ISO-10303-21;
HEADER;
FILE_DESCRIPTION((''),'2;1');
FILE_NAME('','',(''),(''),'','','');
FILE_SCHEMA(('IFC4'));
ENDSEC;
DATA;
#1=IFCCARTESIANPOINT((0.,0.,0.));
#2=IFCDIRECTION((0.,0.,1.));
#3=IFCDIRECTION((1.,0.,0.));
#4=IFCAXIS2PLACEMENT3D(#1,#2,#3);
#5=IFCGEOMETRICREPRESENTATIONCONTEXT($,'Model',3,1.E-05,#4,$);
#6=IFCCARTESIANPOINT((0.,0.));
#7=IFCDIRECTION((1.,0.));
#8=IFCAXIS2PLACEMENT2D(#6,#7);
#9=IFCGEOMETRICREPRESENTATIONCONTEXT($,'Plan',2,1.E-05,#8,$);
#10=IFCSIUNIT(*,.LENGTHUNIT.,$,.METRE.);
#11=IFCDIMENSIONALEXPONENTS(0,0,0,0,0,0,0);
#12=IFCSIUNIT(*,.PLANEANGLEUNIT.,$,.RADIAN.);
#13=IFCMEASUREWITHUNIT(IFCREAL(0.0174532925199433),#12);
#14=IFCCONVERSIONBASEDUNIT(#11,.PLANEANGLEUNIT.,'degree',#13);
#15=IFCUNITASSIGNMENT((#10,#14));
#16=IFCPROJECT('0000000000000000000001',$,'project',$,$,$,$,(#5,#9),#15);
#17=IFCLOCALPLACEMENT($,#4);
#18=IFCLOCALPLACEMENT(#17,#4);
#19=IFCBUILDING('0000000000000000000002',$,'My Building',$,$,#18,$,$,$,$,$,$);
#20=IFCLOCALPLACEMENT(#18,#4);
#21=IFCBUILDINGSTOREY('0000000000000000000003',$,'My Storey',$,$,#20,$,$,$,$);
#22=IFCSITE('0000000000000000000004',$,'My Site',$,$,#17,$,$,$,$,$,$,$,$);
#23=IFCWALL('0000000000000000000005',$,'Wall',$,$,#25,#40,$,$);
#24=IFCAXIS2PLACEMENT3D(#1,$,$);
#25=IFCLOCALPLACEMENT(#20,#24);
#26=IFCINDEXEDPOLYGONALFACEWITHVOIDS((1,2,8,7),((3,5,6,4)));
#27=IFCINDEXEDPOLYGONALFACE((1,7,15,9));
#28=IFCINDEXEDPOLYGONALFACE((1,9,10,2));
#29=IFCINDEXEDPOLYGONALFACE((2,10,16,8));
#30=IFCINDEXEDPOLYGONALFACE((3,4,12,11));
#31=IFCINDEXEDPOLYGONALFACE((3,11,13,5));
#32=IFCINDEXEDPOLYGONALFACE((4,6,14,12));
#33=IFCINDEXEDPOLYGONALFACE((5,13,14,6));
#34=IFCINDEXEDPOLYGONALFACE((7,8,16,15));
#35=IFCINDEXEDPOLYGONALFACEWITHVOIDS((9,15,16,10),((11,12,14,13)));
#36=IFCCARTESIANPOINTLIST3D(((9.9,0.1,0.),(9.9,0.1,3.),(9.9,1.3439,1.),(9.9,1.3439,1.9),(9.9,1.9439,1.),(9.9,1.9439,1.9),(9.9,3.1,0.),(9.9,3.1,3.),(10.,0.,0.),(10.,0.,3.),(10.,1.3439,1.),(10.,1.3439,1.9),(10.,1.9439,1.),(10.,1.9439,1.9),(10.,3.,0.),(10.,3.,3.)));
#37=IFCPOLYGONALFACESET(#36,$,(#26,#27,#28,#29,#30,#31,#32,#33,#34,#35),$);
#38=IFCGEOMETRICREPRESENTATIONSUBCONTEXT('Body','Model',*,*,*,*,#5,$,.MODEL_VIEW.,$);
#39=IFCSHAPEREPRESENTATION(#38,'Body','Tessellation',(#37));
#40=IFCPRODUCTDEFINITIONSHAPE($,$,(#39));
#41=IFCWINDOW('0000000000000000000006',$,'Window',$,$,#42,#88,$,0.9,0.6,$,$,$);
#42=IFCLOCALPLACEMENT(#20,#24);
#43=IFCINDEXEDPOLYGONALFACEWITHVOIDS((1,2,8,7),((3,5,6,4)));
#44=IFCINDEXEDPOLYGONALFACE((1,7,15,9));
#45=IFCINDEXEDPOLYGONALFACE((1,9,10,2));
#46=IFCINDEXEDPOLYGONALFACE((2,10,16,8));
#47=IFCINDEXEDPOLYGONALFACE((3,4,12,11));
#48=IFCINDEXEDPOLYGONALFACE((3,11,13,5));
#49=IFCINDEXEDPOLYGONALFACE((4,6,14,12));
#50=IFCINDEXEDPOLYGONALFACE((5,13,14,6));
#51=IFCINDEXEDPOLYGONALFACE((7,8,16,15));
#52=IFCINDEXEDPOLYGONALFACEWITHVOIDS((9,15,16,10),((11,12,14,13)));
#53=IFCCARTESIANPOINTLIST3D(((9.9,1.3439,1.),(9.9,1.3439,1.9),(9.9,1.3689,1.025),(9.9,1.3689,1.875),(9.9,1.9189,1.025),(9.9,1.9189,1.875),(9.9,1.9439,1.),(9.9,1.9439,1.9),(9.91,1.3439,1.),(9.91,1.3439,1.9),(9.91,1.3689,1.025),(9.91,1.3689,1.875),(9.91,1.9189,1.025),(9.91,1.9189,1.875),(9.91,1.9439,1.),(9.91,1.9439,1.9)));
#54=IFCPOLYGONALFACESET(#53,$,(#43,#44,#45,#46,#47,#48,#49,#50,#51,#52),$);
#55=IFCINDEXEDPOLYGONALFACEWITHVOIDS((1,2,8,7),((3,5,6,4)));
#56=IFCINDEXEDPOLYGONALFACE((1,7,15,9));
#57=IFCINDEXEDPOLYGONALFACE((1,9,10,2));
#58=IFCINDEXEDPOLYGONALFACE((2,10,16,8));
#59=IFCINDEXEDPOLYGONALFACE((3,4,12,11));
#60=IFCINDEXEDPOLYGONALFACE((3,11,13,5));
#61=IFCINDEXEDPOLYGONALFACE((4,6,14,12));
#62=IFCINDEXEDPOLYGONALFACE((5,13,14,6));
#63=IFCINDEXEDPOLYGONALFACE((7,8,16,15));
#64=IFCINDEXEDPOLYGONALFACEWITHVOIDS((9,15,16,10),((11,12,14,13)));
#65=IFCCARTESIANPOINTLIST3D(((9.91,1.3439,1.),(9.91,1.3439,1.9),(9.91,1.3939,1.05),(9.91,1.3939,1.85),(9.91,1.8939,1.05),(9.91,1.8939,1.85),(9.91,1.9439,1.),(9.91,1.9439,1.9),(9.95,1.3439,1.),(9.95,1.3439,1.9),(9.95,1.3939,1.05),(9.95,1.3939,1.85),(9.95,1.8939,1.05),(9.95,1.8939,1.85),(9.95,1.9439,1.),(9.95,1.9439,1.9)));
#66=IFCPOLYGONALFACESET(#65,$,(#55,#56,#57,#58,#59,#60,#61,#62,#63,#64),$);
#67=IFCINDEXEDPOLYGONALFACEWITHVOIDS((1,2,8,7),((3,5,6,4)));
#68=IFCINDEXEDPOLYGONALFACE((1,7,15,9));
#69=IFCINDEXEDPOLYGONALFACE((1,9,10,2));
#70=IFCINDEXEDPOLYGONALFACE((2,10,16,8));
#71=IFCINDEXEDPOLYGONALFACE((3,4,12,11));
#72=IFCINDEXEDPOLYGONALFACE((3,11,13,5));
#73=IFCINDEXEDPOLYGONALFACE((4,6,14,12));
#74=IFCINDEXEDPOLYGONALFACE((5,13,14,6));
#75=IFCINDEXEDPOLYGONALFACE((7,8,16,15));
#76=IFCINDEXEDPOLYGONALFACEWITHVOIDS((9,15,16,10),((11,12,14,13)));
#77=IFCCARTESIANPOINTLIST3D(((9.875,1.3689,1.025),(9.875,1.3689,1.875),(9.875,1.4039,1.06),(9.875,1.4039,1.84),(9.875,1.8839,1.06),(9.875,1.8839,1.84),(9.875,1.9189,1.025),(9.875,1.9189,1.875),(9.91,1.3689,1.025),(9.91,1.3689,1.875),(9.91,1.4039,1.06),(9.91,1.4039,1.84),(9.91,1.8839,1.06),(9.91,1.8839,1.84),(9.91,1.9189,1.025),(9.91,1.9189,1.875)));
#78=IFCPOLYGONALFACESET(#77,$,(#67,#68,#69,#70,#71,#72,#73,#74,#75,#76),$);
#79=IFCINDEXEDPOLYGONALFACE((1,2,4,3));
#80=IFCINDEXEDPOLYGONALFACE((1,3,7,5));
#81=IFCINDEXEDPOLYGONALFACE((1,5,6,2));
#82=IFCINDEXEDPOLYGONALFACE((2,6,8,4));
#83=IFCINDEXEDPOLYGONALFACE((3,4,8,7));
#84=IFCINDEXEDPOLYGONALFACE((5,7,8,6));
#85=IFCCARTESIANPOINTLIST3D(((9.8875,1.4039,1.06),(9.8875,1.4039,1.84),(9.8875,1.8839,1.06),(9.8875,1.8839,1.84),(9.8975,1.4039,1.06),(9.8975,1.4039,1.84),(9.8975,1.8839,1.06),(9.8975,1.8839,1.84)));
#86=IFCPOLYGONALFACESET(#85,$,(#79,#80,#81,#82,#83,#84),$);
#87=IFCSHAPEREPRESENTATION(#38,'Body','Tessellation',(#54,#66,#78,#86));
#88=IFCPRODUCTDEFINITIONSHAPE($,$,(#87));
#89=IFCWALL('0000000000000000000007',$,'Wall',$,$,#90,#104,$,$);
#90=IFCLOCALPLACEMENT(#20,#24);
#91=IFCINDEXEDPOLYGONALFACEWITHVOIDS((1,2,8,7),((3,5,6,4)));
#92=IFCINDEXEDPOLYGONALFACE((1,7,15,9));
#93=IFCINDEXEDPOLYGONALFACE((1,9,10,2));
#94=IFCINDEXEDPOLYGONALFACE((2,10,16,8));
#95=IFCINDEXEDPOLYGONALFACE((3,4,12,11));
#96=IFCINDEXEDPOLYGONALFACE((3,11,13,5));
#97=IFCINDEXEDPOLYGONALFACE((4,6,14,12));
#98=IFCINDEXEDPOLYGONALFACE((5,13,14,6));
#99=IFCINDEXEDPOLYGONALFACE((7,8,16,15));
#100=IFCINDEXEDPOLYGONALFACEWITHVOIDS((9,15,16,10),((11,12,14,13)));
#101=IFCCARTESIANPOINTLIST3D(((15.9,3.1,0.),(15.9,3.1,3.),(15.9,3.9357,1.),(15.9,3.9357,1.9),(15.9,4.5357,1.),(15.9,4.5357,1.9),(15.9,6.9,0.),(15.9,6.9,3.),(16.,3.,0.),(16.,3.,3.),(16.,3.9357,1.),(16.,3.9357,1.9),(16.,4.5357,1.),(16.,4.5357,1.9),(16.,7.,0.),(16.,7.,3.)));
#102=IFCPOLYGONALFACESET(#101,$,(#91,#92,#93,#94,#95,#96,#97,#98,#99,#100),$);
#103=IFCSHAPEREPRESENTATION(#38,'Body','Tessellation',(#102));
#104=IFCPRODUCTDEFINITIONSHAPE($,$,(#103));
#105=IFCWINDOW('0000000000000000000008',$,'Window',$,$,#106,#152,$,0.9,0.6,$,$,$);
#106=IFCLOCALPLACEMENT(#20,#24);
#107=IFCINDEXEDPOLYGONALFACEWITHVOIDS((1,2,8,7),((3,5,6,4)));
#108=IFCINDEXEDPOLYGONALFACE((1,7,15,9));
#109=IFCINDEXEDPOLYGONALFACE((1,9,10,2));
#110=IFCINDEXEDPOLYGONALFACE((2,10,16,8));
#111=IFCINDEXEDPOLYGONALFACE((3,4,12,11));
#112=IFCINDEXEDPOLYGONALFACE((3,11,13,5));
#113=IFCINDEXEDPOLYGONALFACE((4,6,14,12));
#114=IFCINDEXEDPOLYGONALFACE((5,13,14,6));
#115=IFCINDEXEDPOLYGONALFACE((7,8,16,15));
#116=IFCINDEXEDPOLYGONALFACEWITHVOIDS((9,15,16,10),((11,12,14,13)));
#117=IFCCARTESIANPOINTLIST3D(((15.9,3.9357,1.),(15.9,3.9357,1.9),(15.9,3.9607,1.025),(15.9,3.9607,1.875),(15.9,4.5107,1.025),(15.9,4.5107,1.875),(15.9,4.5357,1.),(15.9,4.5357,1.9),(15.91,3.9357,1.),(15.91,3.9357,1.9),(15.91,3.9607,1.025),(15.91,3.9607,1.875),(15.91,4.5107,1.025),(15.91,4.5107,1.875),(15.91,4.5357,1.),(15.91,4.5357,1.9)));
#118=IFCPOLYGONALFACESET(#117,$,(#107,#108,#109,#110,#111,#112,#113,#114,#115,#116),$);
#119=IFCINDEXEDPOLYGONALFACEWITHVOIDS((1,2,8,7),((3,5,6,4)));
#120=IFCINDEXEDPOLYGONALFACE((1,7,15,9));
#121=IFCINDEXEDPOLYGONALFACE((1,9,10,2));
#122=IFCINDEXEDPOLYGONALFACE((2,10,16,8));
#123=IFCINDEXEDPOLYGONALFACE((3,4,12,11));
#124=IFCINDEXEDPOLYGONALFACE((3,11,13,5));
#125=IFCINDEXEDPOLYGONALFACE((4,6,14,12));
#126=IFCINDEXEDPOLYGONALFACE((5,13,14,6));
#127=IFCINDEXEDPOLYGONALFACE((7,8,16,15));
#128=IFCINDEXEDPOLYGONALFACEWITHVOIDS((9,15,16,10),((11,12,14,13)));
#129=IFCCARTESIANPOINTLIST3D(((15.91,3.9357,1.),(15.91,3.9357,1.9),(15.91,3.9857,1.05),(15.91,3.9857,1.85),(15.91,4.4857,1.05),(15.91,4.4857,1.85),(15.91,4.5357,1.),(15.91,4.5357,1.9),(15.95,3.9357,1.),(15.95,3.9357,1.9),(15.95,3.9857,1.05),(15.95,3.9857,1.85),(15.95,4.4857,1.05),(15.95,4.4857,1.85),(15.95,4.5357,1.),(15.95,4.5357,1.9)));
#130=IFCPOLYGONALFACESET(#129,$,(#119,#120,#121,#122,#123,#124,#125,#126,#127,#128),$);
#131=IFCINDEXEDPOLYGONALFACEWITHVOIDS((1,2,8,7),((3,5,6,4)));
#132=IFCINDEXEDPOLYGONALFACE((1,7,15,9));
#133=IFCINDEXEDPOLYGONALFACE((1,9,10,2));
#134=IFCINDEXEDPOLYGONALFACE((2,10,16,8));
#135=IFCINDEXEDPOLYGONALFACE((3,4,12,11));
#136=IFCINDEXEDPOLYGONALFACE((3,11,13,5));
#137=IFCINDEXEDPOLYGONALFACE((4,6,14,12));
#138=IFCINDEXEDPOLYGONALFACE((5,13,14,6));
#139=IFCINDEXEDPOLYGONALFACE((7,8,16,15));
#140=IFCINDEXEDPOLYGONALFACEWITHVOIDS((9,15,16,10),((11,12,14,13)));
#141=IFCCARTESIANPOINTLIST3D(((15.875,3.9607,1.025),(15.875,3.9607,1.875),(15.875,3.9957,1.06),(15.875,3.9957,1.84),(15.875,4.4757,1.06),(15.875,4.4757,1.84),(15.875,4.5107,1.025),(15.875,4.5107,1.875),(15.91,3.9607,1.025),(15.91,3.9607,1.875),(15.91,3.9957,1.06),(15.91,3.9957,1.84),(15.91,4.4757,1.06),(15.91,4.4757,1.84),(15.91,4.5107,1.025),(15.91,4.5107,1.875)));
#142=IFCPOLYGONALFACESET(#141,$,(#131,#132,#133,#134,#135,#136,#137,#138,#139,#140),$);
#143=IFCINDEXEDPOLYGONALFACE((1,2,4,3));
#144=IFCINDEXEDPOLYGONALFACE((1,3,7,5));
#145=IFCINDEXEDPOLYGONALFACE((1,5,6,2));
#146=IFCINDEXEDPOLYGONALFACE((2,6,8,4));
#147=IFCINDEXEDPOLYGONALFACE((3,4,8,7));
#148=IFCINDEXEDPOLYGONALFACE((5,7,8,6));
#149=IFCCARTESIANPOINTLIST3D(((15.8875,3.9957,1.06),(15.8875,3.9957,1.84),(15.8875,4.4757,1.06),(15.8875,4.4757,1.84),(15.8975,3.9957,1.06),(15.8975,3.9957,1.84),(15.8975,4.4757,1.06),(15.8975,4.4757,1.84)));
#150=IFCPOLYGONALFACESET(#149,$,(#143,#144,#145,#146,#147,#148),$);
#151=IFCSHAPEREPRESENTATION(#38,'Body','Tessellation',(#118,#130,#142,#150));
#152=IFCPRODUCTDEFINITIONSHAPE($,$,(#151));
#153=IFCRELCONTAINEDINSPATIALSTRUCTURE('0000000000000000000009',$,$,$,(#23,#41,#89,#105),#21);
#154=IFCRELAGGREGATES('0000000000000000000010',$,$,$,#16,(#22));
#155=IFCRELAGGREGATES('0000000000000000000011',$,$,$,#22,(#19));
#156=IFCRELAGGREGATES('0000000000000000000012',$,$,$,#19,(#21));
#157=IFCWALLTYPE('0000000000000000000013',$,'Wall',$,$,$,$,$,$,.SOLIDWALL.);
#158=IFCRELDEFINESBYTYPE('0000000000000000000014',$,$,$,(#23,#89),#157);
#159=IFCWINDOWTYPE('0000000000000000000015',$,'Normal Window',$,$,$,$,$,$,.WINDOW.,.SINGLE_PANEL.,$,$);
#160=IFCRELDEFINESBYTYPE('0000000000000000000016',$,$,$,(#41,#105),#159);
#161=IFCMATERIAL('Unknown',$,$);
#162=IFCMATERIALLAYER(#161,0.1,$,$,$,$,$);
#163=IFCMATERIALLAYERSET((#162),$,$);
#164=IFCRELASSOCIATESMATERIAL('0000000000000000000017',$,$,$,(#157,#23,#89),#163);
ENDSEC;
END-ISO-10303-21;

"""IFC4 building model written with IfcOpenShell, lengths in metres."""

from ifc_helpers import new_model, entity, si_unit, converted_unit, frame, origin_with_axes, origin_2d_with_axis, place, context, subcontext, project, spatial, line, indexed_curve, outline, extrude, shape, source, transform, mapped, material, layer, layer_set, layer_usage, type_object, type_shapes, element, fill, save


model = new_model("IFC4")

# Units and contexts
model_context = context("Model", 3, precision=1e-05, world=origin_with_axes())
plan_context = context("Plan", 2, precision=1e-05, world=origin_2d_with_axis())
body_context_1 = subcontext(model_context, "Body", "Model", "MODEL_VIEW")
body_context_2 = subcontext(plan_context, "Body", "Plan", "PLAN_VIEW")
ifc_project = project(units=[si_unit("LENGTHUNIT", "METRE"), converted_unit("PLANEANGLEUNIT", "degree", entity("IfcReal", 0.0174532925199433), si_unit("PLANEANGLEUNIT", "RADIAN"), dimensions=[0, 0, 0, 0, 0, 0, 0])], contexts=[model_context, plan_context])

# Site, building, storey
site_placement = place(None, origin_with_axes())
site = spatial("IfcSite", under=ifc_project, at=site_placement, Name="My Site")
building_placement = place(site_placement, origin_with_axes())
building = spatial("IfcBuilding", under=site, at=building_placement, Name="My Building")
storey_placement = place(building_placement, origin_with_axes())
storey = spatial("IfcBuildingStorey", under=building, at=storey_placement, Name="My Storey")

# Shared definitions
ifc_material = material(Name="Unknown")

# Walls, openings, windows
ifc_layer = layer(ifc_material, 0.1)
ifc_layer_set = layer_set([ifc_layer])
ifc_layer_usage_1 = layer_usage(ifc_layer_set, "AXIS2", "POSITIVE", 0.0)
wall_type = type_object("IfcWallType", Name="Wall", PredefinedType="SOLIDWALL", material=ifc_layer_set)
wall_1_placement = place(storey_placement, frame((10.0, 0.0, 0.0), z_axis=(0.0, 0.0, 1.0), x_axis=(0.0, 1.0, 0.0)))
wall_1 = element("IfcWall", 1, at=wall_1_placement, inside=storey, type_object=wall_type, material=ifc_layer_usage_1, Name="Wall", context=body_context_1, shape_type="SweptSolid", body=[
    extrude(outline(indexed_curve([(0.0, 0.0), (0.1, 0.1), (3.1, 0.1), (3.0, 0.0)], segments=[line(1, 2, 3, 4, 1)])), origin_with_axes(), (0.0, 0.0, 1.0), 3.0),
])
shared_shape_1 = source(origin_with_axes(), body_context_1, "Body", "SweptSolid", [
    extrude(outline(indexed_curve([(0.0, 0.0), (0.6, 0.0), (0.6, 0.9), (0.0, 0.9)], segments=[line(1, 2, 3, 4, 1)])), frame((0.0, -0.6, 0.0), z_axis=(0.0, -1.0, 0.0), x_axis=(1.0, 0.0, 0.0)), (0.0, 0.0, -1.0), 1.2),
])
opening_1_placement = place(wall_1_placement, frame((1.3439, 0.0, 1.0), z_axis=(0.0, 0.0, 1.0), x_axis=(1.0, 0.0, 0.0)))
opening_1 = element("IfcOpeningElement", 2, at=opening_1_placement, cuts=wall_1, PredefinedType="OPENING", context=body_context_1, shape_type="MappedRepresentation", body=[
    mapped(shared_shape_1, transform((0.0, 0.0, 0.0), x_axis=(1.0, 0.0, 0.0), y_axis=(0.0, 1.0, 0.0), z_axis=(0.0, 0.0, 1.0), scale=1.0)),
])
window_type = type_object("IfcWindowType", Name="Normal Window", PartitioningType="SINGLE_PANEL", PredefinedType="WINDOW")
shared_shape_2 = source(origin_with_axes(), body_context_1, "Body", "SweptSolid", [
    extrude(outline(indexed_curve([(0.0, 0.0), (0.6, 0.0), (0.6, 0.9), (0.0, 0.9)], segments=[line(1, 2, 3, 4, 1)]), holes=[indexed_curve([(0.025, 0.025), (0.575, 0.025), (0.575, 0.875), (0.025, 0.875)], segments=[line(1, 2, 3, 4, 1)])]), frame((0.0, 0.09, 0.0), z_axis=(0.0, -1.0, 0.0), x_axis=(1.0, 0.0, 0.0)), (0.0, 0.0, -1.0), 0.01),
    extrude(outline(indexed_curve([(0.0, 0.0), (0.6, 0.0), (0.6, 0.9), (0.0, 0.9)], segments=[line(1, 2, 3, 4, 1)]), holes=[indexed_curve([(0.05, 0.05), (0.55, 0.05), (0.55, 0.85), (0.05, 0.85)], segments=[line(1, 2, 3, 4, 1)])]), frame((0.0, 0.05, 0.0), z_axis=(0.0, -1.0, 0.0), x_axis=(1.0, 0.0, 0.0)), (0.0, 0.0, -1.0), 0.04),
    extrude(outline(indexed_curve([(0.0, 0.0), (0.55, 0.0), (0.55, 0.85), (0.0, 0.85)], segments=[line(1, 2, 3, 4, 1)]), holes=[indexed_curve([(0.035, 0.035), (0.515, 0.035), (0.515, 0.815), (0.035, 0.815)], segments=[line(1, 2, 3, 4, 1)])]), frame((0.025, 0.09, 0.025), z_axis=(0.0, -1.0, 0.0), x_axis=(1.0, 0.0, 0.0)), (0.0, 0.0, -1.0), 0.035),
    extrude(outline(indexed_curve([(0.035, 0.035), (0.515, 0.035), (0.515, 0.815), (0.035, 0.815)], segments=[line(1, 2, 3, 4, 1)])), frame((0.025, 0.1025, 0.025), z_axis=(0.0, -1.0, 0.0), x_axis=(1.0, 0.0, 0.0)), (0.0, 0.0, -1.0), 0.01),
])
shared_shape_3 = source(origin_with_axes(), body_context_2, "Body", "Curve2D", [
    entity("IfcIndexedPolyCurve", entity("IfcCartesianPointList2D", [[0.05, 0.05], [0.55, 0.05]])),
    entity("IfcIndexedPolyCurve", entity("IfcCartesianPointList2D", [[0.0, 0.1], [0.025, 0.1], [0.025, 0.09], [0.05, 0.09], [0.05, 0.05], [0.0, 0.05]]), [entity("IfcLineIndex", [1, 2, 3, 4, 5, 6, 1])]),
    entity("IfcIndexedPolyCurve", entity("IfcCartesianPointList2D", [[0.6, 0.1], [0.575, 0.1], [0.575, 0.09], [0.55, 0.09], [0.55, 0.05], [0.6, 0.05]]), [entity("IfcLineIndex", [1, 2, 3, 4, 5, 6, 1])]),
    entity("IfcIndexedPolyCurve", entity("IfcCartesianPointList2D", [[0.025, 0.09], [0.06, 0.09], [0.06, 0.125], [0.025, 0.125]]), [entity("IfcLineIndex", [1, 2, 3, 4, 1])]),
    entity("IfcIndexedPolyCurve", entity("IfcCartesianPointList2D", [[0.575, 0.09], [0.54, 0.09], [0.54, 0.125], [0.575, 0.125]]), [entity("IfcLineIndex", [1, 2, 3, 4, 1])]),
    entity("IfcIndexedPolyCurve", entity("IfcCartesianPointList2D", [[0.06, 0.09], [0.54, 0.09]])),
    entity("IfcIndexedPolyCurve", entity("IfcCartesianPointList2D", [[0.06, 0.125], [0.54, 0.125]])),
    entity("IfcIndexedPolyCurve", entity("IfcCartesianPointList2D", [[0.06, 0.1075], [0.54, 0.1075]])),
])
type_shapes(window_type, [shared_shape_2, shared_shape_3])
window_1_placement = place(opening_1_placement, frame((0.0, 0.0, 0.0), z_axis=(0.0, 0.0, 1.0), x_axis=(1.0, 0.0, 0.0)))
window_1 = element("IfcWindow", 3, at=window_1_placement, inside=storey, type_object=window_type, Name="Window", OverallHeight=0.9, OverallWidth=0.6, shapes=[
    shape(body_context_1, "Body", "MappedRepresentation", [mapped(shared_shape_2, transform((0.0, 0.0, 0.0), x_axis=(1.0, 0.0, 0.0), y_axis=(0.0, 1.0, 0.0), z_axis=(0.0, 0.0, 1.0), scale=1.0))]),
    shape(body_context_2, "Body", "MappedRepresentation", [mapped(shared_shape_3, transform((0.0, 0.0, 0.0), x_axis=(1.0, 0.0, 0.0), y_axis=(0.0, 1.0, 0.0), z_axis=(0.0, 0.0, 1.0), scale=1.0))]),
])
fill(opening_1, window_1)
ifc_layer_usage_2 = layer_usage(ifc_layer_set, "AXIS2", "POSITIVE", 0.0)
wall_2_placement = place(storey_placement, frame((16.0, 3.0, 0.0), z_axis=(0.0, 0.0, 1.0), x_axis=(0.0, 1.0, 0.0)))
wall_2 = element("IfcWall", 4, at=wall_2_placement, inside=storey, type_object=wall_type, material=ifc_layer_usage_2, Name="Wall", context=body_context_1, shape_type="SweptSolid", body=[
    extrude(outline(indexed_curve([(0.0, 0.0), (0.1, 0.1), (3.9, 0.1), (4.0, 0.0)], segments=[line(1, 2, 3, 4, 1)])), origin_with_axes(), (0.0, 0.0, 1.0), 3.0),
])
opening_2_placement = place(wall_2_placement, frame((0.9357, 0.0, 1.0), z_axis=(0.0, 0.0, 1.0), x_axis=(1.0, 0.0, 0.0)))
opening_2 = element("IfcOpeningElement", 5, at=opening_2_placement, cuts=wall_2, PredefinedType="OPENING", context=body_context_1, shape_type="MappedRepresentation", body=[
    mapped(shared_shape_1, transform((0.0, 0.0, 0.0), x_axis=(1.0, 0.0, 0.0), y_axis=(0.0, 1.0, 0.0), z_axis=(0.0, 0.0, 1.0), scale=1.0)),
])
window_2_placement = place(opening_2_placement, frame((0.0, 0.0, 0.0), z_axis=(0.0, 0.0, 1.0), x_axis=(1.0, 0.0, 0.0)))
window_2 = element("IfcWindow", 6, at=window_2_placement, inside=storey, type_object=window_type, Name="Window", OverallHeight=0.9, OverallWidth=0.6, shapes=[
    shape(body_context_1, "Body", "MappedRepresentation", [mapped(shared_shape_2, transform((0.0, 0.0, 0.0), x_axis=(1.0, 0.0, 0.0), y_axis=(0.0, 1.0, 0.0), z_axis=(0.0, 0.0, 1.0), scale=1.0))]),
    shape(body_context_2, "Body", "MappedRepresentation", [mapped(shared_shape_3, transform((0.0, 0.0, 0.0), x_axis=(1.0, 0.0, 0.0), y_axis=(0.0, 1.0, 0.0), z_axis=(0.0, 0.0, 1.0), scale=1.0))]),
])
fill(opening_2, window_2)

save(model, "model.ifc")
